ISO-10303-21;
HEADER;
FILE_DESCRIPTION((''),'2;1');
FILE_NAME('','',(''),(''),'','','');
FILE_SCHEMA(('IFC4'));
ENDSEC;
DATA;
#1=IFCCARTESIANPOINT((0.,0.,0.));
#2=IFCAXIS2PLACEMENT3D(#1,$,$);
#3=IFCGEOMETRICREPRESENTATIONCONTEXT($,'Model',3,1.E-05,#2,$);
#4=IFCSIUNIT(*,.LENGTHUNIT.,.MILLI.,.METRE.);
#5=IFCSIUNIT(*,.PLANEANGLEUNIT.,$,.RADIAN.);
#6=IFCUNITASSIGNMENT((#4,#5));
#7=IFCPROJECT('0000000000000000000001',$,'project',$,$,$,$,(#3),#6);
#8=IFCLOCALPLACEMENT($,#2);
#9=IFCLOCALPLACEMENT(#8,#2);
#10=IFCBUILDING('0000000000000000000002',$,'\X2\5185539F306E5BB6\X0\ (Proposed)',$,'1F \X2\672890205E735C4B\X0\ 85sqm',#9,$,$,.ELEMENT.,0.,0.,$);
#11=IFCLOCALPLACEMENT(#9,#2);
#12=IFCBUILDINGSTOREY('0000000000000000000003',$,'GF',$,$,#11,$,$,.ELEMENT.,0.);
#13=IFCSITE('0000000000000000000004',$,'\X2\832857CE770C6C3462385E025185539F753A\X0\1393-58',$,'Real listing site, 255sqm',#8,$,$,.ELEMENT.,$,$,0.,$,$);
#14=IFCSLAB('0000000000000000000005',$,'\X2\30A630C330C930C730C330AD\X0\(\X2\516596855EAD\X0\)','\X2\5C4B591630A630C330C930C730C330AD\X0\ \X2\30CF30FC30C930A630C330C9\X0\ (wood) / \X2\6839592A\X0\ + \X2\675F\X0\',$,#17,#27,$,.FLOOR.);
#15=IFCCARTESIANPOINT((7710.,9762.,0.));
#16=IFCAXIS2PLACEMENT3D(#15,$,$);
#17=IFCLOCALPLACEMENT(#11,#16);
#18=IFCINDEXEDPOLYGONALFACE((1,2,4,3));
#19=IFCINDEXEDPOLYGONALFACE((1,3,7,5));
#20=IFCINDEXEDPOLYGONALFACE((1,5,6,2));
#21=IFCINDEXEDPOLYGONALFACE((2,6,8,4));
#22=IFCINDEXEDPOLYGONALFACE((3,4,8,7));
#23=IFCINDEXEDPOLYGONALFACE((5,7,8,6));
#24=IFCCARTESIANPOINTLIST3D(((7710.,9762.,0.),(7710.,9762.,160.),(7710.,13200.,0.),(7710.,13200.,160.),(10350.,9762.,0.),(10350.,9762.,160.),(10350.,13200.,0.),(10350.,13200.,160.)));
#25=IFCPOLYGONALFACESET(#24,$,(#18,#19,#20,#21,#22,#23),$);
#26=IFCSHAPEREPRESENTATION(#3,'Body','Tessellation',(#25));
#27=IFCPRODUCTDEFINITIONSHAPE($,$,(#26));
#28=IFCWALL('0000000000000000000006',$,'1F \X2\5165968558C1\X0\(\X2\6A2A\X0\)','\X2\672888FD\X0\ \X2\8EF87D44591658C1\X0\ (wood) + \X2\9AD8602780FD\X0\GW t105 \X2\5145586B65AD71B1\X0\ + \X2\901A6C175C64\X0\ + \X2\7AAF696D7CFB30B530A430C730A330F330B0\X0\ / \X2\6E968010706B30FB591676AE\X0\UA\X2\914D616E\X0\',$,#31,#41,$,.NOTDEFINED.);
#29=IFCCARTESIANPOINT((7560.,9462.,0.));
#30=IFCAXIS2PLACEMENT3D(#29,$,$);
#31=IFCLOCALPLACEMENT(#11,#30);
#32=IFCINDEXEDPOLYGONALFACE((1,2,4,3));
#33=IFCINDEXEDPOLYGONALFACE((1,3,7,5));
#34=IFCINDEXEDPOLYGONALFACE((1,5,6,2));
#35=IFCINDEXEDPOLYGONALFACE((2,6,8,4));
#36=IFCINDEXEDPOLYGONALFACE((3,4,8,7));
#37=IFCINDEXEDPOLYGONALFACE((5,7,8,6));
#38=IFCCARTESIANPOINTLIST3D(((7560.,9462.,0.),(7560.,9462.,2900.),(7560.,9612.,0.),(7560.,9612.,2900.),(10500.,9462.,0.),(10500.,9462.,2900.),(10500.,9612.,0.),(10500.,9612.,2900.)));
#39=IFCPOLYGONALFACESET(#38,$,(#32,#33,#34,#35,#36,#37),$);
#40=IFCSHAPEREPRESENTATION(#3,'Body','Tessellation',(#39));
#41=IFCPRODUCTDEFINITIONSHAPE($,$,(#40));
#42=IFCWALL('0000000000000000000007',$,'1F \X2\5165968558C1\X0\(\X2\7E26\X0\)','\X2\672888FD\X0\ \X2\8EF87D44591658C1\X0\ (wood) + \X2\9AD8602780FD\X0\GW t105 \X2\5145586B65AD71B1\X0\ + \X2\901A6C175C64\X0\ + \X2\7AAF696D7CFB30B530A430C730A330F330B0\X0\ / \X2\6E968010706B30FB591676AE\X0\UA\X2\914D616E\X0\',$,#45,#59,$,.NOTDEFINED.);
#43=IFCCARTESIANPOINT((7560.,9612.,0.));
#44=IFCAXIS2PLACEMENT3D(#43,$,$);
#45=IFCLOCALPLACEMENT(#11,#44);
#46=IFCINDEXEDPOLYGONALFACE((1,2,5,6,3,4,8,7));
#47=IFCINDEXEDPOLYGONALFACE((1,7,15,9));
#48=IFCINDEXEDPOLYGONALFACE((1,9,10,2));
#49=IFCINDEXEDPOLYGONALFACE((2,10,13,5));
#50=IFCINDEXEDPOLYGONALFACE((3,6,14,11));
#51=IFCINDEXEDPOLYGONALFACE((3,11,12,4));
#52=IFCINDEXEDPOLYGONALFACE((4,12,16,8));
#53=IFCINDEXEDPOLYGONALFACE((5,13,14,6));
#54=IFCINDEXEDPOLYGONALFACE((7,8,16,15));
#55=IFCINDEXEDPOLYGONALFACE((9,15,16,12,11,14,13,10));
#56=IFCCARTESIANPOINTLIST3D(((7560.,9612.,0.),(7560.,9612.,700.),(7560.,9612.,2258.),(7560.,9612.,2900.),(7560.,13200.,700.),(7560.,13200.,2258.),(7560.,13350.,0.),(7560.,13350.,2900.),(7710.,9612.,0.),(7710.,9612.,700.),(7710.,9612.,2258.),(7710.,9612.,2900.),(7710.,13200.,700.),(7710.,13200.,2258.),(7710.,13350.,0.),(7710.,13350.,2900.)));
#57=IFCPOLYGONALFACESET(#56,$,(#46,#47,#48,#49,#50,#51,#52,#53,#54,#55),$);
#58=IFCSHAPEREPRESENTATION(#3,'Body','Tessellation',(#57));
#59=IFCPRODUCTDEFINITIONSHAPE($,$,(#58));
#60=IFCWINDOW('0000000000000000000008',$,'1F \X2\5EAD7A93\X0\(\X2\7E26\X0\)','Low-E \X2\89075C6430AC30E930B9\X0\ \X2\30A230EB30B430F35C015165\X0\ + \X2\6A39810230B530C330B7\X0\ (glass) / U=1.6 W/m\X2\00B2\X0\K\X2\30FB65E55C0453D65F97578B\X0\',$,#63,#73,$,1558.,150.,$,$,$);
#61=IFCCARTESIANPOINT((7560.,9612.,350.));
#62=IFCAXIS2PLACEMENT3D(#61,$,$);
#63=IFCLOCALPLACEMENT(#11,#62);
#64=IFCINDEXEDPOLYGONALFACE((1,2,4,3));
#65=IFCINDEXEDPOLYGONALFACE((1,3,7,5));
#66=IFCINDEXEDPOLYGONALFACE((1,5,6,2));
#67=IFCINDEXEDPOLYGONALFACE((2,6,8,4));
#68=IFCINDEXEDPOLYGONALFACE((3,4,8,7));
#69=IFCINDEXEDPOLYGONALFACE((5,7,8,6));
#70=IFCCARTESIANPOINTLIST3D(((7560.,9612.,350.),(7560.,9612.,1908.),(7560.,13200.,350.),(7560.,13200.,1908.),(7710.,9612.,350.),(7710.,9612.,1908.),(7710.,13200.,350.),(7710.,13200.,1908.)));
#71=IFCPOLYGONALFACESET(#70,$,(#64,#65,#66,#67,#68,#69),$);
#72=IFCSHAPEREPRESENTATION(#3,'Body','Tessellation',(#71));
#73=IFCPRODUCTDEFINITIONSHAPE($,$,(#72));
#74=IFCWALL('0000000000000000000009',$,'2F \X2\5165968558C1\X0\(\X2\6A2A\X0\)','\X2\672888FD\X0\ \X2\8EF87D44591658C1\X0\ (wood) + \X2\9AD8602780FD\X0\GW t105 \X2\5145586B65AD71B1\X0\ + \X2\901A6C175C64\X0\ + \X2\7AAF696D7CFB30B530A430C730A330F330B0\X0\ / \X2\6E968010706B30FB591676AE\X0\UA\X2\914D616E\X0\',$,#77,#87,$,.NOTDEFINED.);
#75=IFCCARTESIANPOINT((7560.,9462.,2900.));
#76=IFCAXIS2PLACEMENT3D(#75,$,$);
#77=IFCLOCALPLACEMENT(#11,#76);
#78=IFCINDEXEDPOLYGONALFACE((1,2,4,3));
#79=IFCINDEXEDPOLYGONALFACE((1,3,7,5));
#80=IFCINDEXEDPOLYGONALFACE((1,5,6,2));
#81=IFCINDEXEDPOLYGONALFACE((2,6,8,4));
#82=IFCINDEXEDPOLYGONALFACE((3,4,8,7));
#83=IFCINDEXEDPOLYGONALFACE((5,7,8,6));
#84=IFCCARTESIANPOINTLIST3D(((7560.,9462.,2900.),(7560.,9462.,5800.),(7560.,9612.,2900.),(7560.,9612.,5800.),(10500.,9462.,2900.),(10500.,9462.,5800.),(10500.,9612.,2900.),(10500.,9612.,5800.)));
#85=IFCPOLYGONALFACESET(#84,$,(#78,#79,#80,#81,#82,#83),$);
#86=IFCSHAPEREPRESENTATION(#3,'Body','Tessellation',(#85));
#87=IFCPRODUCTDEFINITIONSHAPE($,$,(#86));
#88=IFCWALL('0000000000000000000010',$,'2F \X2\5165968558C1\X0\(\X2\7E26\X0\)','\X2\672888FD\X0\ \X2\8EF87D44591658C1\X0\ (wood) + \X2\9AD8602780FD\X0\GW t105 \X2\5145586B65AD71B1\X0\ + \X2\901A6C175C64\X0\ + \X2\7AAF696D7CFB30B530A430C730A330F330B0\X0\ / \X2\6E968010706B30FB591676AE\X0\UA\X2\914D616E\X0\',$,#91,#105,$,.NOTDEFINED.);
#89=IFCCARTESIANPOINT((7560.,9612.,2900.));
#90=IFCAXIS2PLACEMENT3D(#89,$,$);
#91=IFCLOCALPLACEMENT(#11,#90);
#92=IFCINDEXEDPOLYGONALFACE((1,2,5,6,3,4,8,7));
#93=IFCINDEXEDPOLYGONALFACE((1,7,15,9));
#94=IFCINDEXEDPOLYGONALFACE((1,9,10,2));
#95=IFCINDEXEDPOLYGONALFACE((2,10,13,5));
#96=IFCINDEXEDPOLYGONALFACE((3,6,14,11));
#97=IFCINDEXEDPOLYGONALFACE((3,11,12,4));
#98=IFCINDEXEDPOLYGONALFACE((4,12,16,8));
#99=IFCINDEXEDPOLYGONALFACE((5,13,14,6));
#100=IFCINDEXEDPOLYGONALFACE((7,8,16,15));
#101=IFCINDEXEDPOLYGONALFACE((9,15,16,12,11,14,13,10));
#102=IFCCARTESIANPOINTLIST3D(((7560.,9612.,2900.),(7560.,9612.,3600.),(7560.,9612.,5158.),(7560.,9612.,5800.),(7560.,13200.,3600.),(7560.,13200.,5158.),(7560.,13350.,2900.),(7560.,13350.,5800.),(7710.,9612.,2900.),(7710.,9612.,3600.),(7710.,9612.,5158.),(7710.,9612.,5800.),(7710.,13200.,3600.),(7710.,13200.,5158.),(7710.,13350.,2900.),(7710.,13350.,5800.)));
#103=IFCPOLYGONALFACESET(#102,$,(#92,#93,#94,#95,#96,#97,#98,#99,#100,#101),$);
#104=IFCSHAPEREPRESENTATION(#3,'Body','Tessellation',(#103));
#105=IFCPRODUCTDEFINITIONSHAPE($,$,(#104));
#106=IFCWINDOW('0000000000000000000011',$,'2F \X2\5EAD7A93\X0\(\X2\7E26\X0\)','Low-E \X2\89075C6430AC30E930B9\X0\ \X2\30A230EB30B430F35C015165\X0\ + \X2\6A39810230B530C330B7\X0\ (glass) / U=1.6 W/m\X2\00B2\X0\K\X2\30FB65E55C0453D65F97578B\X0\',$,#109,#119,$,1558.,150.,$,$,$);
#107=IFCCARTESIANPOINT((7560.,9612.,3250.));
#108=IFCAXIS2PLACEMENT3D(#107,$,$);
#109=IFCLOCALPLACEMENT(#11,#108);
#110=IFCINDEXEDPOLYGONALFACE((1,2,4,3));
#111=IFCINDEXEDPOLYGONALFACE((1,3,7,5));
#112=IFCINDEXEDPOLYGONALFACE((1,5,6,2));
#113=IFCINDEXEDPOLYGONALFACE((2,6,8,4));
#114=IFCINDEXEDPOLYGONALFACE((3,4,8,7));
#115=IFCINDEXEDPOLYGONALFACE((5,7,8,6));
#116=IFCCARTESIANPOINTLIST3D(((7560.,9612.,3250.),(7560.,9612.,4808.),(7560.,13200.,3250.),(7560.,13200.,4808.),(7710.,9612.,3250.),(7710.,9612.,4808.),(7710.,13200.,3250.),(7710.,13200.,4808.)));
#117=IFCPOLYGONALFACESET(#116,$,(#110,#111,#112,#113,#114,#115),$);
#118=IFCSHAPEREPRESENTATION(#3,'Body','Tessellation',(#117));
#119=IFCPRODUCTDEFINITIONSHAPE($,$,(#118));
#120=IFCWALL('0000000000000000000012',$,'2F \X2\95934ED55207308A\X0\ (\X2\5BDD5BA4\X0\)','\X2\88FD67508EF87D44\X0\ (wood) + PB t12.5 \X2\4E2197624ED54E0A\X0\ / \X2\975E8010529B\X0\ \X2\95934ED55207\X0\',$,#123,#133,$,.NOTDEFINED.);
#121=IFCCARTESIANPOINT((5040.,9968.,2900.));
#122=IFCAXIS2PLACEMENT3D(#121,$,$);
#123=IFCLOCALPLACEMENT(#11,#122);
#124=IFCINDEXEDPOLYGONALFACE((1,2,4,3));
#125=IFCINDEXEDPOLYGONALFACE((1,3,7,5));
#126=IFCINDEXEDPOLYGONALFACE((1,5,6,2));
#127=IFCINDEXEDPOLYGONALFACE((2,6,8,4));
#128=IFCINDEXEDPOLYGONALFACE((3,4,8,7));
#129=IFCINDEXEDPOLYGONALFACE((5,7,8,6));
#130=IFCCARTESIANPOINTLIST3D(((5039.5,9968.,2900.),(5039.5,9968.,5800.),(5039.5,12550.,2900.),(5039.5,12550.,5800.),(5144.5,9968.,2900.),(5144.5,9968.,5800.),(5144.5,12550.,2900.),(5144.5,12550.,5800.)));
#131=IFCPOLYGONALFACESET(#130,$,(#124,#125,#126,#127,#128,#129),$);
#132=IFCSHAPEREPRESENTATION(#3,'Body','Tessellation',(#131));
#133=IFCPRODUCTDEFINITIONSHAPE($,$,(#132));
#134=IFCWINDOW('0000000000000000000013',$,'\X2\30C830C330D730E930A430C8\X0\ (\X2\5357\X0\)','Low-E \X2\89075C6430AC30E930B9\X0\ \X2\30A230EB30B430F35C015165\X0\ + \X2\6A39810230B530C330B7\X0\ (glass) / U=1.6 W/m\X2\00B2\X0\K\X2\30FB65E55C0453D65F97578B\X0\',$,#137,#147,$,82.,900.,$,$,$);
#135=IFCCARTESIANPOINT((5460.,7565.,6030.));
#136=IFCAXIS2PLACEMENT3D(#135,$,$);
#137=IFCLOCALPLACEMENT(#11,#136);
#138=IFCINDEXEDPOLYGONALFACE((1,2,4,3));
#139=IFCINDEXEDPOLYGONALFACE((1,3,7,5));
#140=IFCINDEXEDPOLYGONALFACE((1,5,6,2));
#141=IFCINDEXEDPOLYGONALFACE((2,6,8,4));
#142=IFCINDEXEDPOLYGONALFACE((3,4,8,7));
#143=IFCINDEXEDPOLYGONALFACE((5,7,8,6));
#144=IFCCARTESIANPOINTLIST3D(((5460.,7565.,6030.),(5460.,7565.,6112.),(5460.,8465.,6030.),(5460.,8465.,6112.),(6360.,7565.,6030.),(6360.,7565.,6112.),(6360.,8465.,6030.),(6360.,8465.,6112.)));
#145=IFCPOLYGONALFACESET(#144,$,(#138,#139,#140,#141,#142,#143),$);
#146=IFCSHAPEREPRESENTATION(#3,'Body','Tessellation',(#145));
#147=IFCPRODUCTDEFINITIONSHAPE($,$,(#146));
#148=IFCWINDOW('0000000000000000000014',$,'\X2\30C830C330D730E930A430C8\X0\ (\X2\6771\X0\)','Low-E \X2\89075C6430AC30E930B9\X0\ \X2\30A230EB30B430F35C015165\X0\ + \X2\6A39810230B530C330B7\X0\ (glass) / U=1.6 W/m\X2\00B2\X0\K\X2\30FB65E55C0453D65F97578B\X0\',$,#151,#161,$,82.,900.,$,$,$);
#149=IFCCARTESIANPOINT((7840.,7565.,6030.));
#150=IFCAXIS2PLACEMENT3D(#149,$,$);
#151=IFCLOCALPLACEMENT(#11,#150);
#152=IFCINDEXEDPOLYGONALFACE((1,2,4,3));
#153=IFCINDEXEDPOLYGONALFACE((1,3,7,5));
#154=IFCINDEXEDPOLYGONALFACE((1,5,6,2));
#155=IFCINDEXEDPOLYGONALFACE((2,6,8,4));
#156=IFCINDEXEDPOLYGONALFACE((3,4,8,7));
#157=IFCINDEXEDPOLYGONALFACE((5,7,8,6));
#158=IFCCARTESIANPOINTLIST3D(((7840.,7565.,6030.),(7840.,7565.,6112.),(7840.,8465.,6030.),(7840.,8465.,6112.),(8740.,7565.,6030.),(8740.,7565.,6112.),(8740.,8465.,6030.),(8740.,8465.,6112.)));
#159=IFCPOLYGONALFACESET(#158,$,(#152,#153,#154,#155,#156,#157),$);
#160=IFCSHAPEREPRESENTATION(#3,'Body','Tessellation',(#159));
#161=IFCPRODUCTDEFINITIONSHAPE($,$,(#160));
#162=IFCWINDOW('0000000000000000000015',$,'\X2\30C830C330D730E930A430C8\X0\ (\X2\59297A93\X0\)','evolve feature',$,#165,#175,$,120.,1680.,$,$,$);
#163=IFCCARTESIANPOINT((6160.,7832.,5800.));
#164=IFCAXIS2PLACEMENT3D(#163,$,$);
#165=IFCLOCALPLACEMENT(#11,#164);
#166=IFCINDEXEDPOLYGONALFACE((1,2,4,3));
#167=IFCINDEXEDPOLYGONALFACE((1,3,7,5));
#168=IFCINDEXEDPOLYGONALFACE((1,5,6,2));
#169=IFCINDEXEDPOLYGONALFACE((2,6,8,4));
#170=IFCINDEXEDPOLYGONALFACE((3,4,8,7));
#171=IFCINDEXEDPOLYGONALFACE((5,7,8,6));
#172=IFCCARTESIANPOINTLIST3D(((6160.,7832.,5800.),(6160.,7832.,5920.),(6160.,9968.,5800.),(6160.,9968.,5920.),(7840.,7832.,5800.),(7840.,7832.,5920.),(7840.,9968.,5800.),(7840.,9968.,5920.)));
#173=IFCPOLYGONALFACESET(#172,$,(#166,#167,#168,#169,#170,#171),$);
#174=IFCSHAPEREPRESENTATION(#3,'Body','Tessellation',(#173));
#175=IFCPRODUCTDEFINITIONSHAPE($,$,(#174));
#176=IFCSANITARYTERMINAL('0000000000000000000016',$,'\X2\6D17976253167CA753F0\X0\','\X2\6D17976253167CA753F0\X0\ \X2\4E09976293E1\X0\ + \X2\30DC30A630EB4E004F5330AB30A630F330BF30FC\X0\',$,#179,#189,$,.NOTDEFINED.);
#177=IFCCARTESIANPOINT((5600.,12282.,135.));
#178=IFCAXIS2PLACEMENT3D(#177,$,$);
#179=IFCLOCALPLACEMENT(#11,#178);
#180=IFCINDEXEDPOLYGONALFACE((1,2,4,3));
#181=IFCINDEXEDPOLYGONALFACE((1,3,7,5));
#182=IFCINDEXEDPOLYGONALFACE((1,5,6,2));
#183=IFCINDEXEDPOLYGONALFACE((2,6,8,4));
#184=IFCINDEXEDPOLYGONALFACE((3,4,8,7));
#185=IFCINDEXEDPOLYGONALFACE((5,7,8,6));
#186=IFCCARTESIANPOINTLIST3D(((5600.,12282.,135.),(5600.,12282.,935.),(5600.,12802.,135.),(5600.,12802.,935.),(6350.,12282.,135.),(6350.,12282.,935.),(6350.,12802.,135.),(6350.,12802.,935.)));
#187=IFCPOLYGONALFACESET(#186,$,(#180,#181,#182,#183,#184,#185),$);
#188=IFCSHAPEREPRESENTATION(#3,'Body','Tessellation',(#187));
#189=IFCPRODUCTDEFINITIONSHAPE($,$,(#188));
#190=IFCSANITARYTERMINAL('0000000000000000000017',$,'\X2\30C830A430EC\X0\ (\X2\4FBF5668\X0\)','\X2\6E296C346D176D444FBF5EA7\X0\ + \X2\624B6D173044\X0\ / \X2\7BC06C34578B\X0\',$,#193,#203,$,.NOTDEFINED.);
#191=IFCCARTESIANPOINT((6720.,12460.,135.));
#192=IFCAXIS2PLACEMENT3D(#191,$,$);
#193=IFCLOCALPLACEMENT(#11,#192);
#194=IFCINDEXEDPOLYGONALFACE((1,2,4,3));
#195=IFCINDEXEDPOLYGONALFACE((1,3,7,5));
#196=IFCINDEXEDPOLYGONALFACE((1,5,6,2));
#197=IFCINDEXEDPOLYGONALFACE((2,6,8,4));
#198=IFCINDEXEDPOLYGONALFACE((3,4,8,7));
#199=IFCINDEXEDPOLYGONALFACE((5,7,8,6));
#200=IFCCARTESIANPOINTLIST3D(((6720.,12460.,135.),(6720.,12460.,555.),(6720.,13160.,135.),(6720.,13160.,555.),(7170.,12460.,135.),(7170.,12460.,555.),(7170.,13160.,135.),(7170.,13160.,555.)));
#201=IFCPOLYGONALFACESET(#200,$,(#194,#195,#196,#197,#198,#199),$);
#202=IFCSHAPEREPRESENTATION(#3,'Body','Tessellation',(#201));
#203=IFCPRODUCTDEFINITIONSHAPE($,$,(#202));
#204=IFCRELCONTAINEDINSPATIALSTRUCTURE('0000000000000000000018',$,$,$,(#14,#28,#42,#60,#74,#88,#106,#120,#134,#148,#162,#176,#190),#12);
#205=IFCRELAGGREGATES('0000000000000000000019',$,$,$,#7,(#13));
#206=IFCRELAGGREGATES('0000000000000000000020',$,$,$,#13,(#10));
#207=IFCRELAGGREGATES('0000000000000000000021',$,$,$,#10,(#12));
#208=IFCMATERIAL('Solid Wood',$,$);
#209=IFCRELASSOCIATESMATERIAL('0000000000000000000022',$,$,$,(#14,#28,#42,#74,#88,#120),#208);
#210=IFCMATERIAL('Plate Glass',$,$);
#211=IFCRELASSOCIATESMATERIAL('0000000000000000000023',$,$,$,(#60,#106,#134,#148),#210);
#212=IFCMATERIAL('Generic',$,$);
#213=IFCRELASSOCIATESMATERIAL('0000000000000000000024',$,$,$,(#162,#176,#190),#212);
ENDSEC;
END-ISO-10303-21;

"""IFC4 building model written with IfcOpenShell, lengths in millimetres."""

from ifc_helpers import new_model, si_unit, frame, frame_2d, origin, place, context, project, spatial, rectangle, extrude, material, element, fill, save


model = new_model("IFC4")

# Units and contexts
model_context = context("Model", 3, precision=1e-05, world=origin())
ifc_project = project(units=[si_unit("LENGTHUNIT", "METRE", prefix="MILLI"), si_unit("PLANEANGLEUNIT", "RADIAN")], contexts=[model_context])

# Site, building, storey
site_placement = place(None, origin())
site = spatial("IfcSite", under=ifc_project, at=site_placement, Name="茨城県水戸市内原町1393-58", ObjectType="Real listing site, 255sqm", CompositionType="ELEMENT", RefElevation=0.0)
building_placement = place(site_placement, origin())
building = spatial("IfcBuilding", under=site, at=building_placement, Name="内原の家 (Proposed)", ObjectType="1F 木造平屋 85sqm", CompositionType="ELEMENT", ElevationOfRefHeight=0.0, ElevationOfTerrain=0.0)
storey_placement = place(building_placement, origin())
storey = spatial("IfcBuildingStorey", under=building, at=storey_placement, Name="GF", CompositionType="ELEMENT", Elevation=0.0)

# Slab
ifc_material_1 = material(Name="Solid Wood")
slab_placement = place(storey_placement, frame((7710.0, 9762.0, 0.0)))
element("IfcSlab", 1, at=slab_placement, inside=storey, material=ifc_material_1, Name="ウッドデッキ(入隅庭)", Description="屋外ウッドデッキ ハードウッド (wood) / 根太 + 束", PredefinedType="FLOOR", context=model_context, shape_type="SweptSolid", body=[
    extrude(rectangle(XDim=2640.0, YDim=3438.0, at=frame_2d((1320.0, 1719.0))), frame((7710.0, 9762.0, 0.0)), (0.0, 0.0, 1.0), 160.0),
])

# Wall
wall_1_placement = place(storey_placement, frame((7560.0, 9462.0, 0.0)))
element("IfcWall", 2, at=wall_1_placement, inside=storey, material=ifc_material_1, Name="1F 入隅壁(横)", Description="木製 軸組外壁 (wood) + 高性能GW t105 充填断熱 + 通気層 + 窯業系サイディング / 準耐火・外皮UA配慮", PredefinedType="NOTDEFINED", context=model_context, shape_type="SweptSolid", body=[
    extrude(rectangle(XDim=2940.0, YDim=150.0, at=frame_2d((1470.0, 75.0))), frame((7560.0, 9462.0, 0.0)), (0.0, 0.0, 1.0), 2900.0),
])

# Wall, opening, window
wall_2_placement = place(storey_placement, frame((7560.0, 9612.0, 0.0)))
wall_2 = element("IfcWall", 3, at=wall_2_placement, inside=storey, material=ifc_material_1, Name="1F 入隅壁(縦)", Description="木製 軸組外壁 (wood) + 高性能GW t105 充填断熱 + 通気層 + 窯業系サイディング / 準耐火・外皮UA配慮", PredefinedType="NOTDEFINED", context=model_context, shape_type="SweptSolid", body=[
    extrude(rectangle(XDim=150.0, YDim=3738.0, at=frame_2d((75.0, 1869.0))), frame((7560.0, 9612.0, 0.0)), (0.0, 0.0, 1.0), 2900.0),
])
opening_1_placement = place(storey_placement, frame((7560.0, 9612.0, 350.0)))
opening_1 = element("IfcOpeningElement", 4, at=opening_1_placement, cuts=wall_2, PredefinedType="NOTDEFINED", context=model_context, shape_type="SweptSolid", body=[
    extrude(rectangle(XDim=150.0, YDim=3588.0, at=frame_2d((75.0, 1794.0))), frame((7560.0, 9612.0, 350.0)), (0.0, 0.0, 1.0), 1558.0),
])
ifc_material_2 = material(Name="Plate Glass")
window_1_placement = place(storey_placement, frame((7560.0, 9612.0, 350.0)))
window_1 = element("IfcWindow", 5, at=window_1_placement, inside=storey, material=ifc_material_2, Name="1F 庭窓(縦)", Description="Low-E 複層ガラス アルゴン封入 + 樹脂サッシ (glass) / U=1.6 W/m²K・日射取得型", OverallHeight=1558.0, OverallWidth=150.0, context=model_context, shape_type="SweptSolid", body=[
    extrude(rectangle(XDim=150.0, YDim=3588.0, at=frame_2d((75.0, 1794.0))), frame((7560.0, 9612.0, 350.0)), (0.0, 0.0, 1.0), 1558.0),
])
fill(opening_1, window_1)

# Wall
wall_3_placement = place(storey_placement, frame((7560.0, 9462.0, 2900.0)))
element("IfcWall", 6, at=wall_3_placement, inside=storey, material=ifc_material_1, Name="2F 入隅壁(横)", Description="木製 軸組外壁 (wood) + 高性能GW t105 充填断熱 + 通気層 + 窯業系サイディング / 準耐火・外皮UA配慮", PredefinedType="NOTDEFINED", context=model_context, shape_type="SweptSolid", body=[
    extrude(rectangle(XDim=2940.0, YDim=150.0, at=frame_2d((1470.0, 75.0))), frame((7560.0, 9462.0, 2900.0)), (0.0, 0.0, 1.0), 2900.0),
])

# Wall, opening, window
wall_4_placement = place(storey_placement, frame((7560.0, 9612.0, 2900.0)))
wall_4 = element("IfcWall", 7, at=wall_4_placement, inside=storey, material=ifc_material_1, Name="2F 入隅壁(縦)", Description="木製 軸組外壁 (wood) + 高性能GW t105 充填断熱 + 通気層 + 窯業系サイディング / 準耐火・外皮UA配慮", PredefinedType="NOTDEFINED", context=model_context, shape_type="SweptSolid", body=[
    extrude(rectangle(XDim=150.0, YDim=3738.0, at=frame_2d((75.0, 1869.0))), frame((7560.0, 9612.0, 2900.0)), (0.0, 0.0, 1.0), 2900.0),
])
opening_2_placement = place(storey_placement, frame((7560.0, 9612.0, 3250.0)))
opening_2 = element("IfcOpeningElement", 8, at=opening_2_placement, cuts=wall_4, PredefinedType="NOTDEFINED", context=model_context, shape_type="SweptSolid", body=[
    extrude(rectangle(XDim=150.0, YDim=3588.0, at=frame_2d((75.0, 1794.0))), frame((7560.0, 9612.0, 3250.0)), (0.0, 0.0, 1.0), 1558.0),
])
window_2_placement = place(storey_placement, frame((7560.0, 9612.0, 3250.0)))
window_2 = element("IfcWindow", 9, at=window_2_placement, inside=storey, material=ifc_material_2, Name="2F 庭窓(縦)", Description="Low-E 複層ガラス アルゴン封入 + 樹脂サッシ (glass) / U=1.6 W/m²K・日射取得型", OverallHeight=1558.0, OverallWidth=150.0, context=model_context, shape_type="SweptSolid", body=[
    extrude(rectangle(XDim=150.0, YDim=3588.0, at=frame_2d((75.0, 1794.0))), frame((7560.0, 9612.0, 3250.0)), (0.0, 0.0, 1.0), 1558.0),
])
fill(opening_2, window_2)

# Wall
wall_5_placement = place(storey_placement, frame((5040.0, 9968.0, 2900.0)))
element("IfcWall", 10, at=wall_5_placement, inside=storey, material=ifc_material_1, Name="2F 間仕切り (寝室)", Description="製材軸組 (wood) + PB t12.5 両面仕上 / 非耐力 間仕切", PredefinedType="NOTDEFINED", context=model_context, shape_type="SweptSolid", body=[
    extrude(rectangle(XDim=105.0, YDim=2582.0, at=frame_2d((52.0, 1291.0))), frame((5040.0, 9968.0, 2900.0)), (0.0, 0.0, 1.0), 2900.0),
])

# Windows
window_3_placement = place(storey_placement, frame((5460.0, 7565.0, 6030.0)))
element("IfcWindow", 11, at=window_3_placement, inside=storey, material=ifc_material_2, Name="トップライト (南)", Description="Low-E 複層ガラス アルゴン封入 + 樹脂サッシ (glass) / U=1.6 W/m²K・日射取得型", OverallHeight=82.0, OverallWidth=900.0, context=model_context, shape_type="SweptSolid", body=[
    extrude(rectangle(XDim=900.0, YDim=900.0, at=frame_2d((450.0, 450.0))), frame((5460.0, 7565.0, 6030.0)), (0.0, 0.0, 1.0), 82.0),
])
window_4_placement = place(storey_placement, frame((7840.0, 7565.0, 6030.0)))
element("IfcWindow", 12, at=window_4_placement, inside=storey, material=ifc_material_2, Name="トップライト (東)", Description="Low-E 複層ガラス アルゴン封入 + 樹脂サッシ (glass) / U=1.6 W/m²K・日射取得型", OverallHeight=82.0, OverallWidth=900.0, context=model_context, shape_type="SweptSolid", body=[
    extrude(rectangle(XDim=900.0, YDim=900.0, at=frame_2d((450.0, 450.0))), frame((7840.0, 7565.0, 6030.0)), (0.0, 0.0, 1.0), 82.0),
])
ifc_material_3 = material(Name="Generic")
window_5_placement = place(storey_placement, frame((6160.0, 7832.0, 5800.0)))
element("IfcWindow", 13, at=window_5_placement, inside=storey, material=ifc_material_3, Name="トップライト (天窓)", Description="evolve feature", OverallHeight=120.0, OverallWidth=1680.0, context=model_context, shape_type="SweptSolid", body=[
    extrude(rectangle(XDim=1680.0, YDim=2136.0, at=frame_2d((840.0, 1068.0))), frame((6160.0, 7832.0, 5800.0)), (0.0, 0.0, 1.0), 120.0),
])

# Sanitary terminals
sanitary_terminal_1_placement = place(storey_placement, frame((5600.0, 12282.0, 135.0)))
element("IfcSanitaryTerminal", 14, at=sanitary_terminal_1_placement, inside=storey, material=ifc_material_3, Name="洗面化粧台", Description="洗面化粧台 三面鏡 + ボウル一体カウンター", PredefinedType="NOTDEFINED", context=model_context, shape_type="SweptSolid", body=[
    extrude(rectangle(XDim=750.0, YDim=520.0, at=frame_2d((375.0, 260.0))), frame((5600.0, 12282.0, 135.0)), (0.0, 0.0, 1.0), 800.0),
])
sanitary_terminal_2_placement = place(storey_placement, frame((6720.0, 12460.0, 135.0)))
element("IfcSanitaryTerminal", 15, at=sanitary_terminal_2_placement, inside=storey, material=ifc_material_3, Name="トイレ (便器)", Description="温水洗浄便座 + 手洗い / 節水型", PredefinedType="NOTDEFINED", context=model_context, shape_type="SweptSolid", body=[
    extrude(rectangle(XDim=450.0, YDim=700.0, at=frame_2d((225.0, 350.0))), frame((6720.0, 12460.0, 135.0)), (0.0, 0.0, 1.0), 420.0),
])

save(model, "model.ifc")
